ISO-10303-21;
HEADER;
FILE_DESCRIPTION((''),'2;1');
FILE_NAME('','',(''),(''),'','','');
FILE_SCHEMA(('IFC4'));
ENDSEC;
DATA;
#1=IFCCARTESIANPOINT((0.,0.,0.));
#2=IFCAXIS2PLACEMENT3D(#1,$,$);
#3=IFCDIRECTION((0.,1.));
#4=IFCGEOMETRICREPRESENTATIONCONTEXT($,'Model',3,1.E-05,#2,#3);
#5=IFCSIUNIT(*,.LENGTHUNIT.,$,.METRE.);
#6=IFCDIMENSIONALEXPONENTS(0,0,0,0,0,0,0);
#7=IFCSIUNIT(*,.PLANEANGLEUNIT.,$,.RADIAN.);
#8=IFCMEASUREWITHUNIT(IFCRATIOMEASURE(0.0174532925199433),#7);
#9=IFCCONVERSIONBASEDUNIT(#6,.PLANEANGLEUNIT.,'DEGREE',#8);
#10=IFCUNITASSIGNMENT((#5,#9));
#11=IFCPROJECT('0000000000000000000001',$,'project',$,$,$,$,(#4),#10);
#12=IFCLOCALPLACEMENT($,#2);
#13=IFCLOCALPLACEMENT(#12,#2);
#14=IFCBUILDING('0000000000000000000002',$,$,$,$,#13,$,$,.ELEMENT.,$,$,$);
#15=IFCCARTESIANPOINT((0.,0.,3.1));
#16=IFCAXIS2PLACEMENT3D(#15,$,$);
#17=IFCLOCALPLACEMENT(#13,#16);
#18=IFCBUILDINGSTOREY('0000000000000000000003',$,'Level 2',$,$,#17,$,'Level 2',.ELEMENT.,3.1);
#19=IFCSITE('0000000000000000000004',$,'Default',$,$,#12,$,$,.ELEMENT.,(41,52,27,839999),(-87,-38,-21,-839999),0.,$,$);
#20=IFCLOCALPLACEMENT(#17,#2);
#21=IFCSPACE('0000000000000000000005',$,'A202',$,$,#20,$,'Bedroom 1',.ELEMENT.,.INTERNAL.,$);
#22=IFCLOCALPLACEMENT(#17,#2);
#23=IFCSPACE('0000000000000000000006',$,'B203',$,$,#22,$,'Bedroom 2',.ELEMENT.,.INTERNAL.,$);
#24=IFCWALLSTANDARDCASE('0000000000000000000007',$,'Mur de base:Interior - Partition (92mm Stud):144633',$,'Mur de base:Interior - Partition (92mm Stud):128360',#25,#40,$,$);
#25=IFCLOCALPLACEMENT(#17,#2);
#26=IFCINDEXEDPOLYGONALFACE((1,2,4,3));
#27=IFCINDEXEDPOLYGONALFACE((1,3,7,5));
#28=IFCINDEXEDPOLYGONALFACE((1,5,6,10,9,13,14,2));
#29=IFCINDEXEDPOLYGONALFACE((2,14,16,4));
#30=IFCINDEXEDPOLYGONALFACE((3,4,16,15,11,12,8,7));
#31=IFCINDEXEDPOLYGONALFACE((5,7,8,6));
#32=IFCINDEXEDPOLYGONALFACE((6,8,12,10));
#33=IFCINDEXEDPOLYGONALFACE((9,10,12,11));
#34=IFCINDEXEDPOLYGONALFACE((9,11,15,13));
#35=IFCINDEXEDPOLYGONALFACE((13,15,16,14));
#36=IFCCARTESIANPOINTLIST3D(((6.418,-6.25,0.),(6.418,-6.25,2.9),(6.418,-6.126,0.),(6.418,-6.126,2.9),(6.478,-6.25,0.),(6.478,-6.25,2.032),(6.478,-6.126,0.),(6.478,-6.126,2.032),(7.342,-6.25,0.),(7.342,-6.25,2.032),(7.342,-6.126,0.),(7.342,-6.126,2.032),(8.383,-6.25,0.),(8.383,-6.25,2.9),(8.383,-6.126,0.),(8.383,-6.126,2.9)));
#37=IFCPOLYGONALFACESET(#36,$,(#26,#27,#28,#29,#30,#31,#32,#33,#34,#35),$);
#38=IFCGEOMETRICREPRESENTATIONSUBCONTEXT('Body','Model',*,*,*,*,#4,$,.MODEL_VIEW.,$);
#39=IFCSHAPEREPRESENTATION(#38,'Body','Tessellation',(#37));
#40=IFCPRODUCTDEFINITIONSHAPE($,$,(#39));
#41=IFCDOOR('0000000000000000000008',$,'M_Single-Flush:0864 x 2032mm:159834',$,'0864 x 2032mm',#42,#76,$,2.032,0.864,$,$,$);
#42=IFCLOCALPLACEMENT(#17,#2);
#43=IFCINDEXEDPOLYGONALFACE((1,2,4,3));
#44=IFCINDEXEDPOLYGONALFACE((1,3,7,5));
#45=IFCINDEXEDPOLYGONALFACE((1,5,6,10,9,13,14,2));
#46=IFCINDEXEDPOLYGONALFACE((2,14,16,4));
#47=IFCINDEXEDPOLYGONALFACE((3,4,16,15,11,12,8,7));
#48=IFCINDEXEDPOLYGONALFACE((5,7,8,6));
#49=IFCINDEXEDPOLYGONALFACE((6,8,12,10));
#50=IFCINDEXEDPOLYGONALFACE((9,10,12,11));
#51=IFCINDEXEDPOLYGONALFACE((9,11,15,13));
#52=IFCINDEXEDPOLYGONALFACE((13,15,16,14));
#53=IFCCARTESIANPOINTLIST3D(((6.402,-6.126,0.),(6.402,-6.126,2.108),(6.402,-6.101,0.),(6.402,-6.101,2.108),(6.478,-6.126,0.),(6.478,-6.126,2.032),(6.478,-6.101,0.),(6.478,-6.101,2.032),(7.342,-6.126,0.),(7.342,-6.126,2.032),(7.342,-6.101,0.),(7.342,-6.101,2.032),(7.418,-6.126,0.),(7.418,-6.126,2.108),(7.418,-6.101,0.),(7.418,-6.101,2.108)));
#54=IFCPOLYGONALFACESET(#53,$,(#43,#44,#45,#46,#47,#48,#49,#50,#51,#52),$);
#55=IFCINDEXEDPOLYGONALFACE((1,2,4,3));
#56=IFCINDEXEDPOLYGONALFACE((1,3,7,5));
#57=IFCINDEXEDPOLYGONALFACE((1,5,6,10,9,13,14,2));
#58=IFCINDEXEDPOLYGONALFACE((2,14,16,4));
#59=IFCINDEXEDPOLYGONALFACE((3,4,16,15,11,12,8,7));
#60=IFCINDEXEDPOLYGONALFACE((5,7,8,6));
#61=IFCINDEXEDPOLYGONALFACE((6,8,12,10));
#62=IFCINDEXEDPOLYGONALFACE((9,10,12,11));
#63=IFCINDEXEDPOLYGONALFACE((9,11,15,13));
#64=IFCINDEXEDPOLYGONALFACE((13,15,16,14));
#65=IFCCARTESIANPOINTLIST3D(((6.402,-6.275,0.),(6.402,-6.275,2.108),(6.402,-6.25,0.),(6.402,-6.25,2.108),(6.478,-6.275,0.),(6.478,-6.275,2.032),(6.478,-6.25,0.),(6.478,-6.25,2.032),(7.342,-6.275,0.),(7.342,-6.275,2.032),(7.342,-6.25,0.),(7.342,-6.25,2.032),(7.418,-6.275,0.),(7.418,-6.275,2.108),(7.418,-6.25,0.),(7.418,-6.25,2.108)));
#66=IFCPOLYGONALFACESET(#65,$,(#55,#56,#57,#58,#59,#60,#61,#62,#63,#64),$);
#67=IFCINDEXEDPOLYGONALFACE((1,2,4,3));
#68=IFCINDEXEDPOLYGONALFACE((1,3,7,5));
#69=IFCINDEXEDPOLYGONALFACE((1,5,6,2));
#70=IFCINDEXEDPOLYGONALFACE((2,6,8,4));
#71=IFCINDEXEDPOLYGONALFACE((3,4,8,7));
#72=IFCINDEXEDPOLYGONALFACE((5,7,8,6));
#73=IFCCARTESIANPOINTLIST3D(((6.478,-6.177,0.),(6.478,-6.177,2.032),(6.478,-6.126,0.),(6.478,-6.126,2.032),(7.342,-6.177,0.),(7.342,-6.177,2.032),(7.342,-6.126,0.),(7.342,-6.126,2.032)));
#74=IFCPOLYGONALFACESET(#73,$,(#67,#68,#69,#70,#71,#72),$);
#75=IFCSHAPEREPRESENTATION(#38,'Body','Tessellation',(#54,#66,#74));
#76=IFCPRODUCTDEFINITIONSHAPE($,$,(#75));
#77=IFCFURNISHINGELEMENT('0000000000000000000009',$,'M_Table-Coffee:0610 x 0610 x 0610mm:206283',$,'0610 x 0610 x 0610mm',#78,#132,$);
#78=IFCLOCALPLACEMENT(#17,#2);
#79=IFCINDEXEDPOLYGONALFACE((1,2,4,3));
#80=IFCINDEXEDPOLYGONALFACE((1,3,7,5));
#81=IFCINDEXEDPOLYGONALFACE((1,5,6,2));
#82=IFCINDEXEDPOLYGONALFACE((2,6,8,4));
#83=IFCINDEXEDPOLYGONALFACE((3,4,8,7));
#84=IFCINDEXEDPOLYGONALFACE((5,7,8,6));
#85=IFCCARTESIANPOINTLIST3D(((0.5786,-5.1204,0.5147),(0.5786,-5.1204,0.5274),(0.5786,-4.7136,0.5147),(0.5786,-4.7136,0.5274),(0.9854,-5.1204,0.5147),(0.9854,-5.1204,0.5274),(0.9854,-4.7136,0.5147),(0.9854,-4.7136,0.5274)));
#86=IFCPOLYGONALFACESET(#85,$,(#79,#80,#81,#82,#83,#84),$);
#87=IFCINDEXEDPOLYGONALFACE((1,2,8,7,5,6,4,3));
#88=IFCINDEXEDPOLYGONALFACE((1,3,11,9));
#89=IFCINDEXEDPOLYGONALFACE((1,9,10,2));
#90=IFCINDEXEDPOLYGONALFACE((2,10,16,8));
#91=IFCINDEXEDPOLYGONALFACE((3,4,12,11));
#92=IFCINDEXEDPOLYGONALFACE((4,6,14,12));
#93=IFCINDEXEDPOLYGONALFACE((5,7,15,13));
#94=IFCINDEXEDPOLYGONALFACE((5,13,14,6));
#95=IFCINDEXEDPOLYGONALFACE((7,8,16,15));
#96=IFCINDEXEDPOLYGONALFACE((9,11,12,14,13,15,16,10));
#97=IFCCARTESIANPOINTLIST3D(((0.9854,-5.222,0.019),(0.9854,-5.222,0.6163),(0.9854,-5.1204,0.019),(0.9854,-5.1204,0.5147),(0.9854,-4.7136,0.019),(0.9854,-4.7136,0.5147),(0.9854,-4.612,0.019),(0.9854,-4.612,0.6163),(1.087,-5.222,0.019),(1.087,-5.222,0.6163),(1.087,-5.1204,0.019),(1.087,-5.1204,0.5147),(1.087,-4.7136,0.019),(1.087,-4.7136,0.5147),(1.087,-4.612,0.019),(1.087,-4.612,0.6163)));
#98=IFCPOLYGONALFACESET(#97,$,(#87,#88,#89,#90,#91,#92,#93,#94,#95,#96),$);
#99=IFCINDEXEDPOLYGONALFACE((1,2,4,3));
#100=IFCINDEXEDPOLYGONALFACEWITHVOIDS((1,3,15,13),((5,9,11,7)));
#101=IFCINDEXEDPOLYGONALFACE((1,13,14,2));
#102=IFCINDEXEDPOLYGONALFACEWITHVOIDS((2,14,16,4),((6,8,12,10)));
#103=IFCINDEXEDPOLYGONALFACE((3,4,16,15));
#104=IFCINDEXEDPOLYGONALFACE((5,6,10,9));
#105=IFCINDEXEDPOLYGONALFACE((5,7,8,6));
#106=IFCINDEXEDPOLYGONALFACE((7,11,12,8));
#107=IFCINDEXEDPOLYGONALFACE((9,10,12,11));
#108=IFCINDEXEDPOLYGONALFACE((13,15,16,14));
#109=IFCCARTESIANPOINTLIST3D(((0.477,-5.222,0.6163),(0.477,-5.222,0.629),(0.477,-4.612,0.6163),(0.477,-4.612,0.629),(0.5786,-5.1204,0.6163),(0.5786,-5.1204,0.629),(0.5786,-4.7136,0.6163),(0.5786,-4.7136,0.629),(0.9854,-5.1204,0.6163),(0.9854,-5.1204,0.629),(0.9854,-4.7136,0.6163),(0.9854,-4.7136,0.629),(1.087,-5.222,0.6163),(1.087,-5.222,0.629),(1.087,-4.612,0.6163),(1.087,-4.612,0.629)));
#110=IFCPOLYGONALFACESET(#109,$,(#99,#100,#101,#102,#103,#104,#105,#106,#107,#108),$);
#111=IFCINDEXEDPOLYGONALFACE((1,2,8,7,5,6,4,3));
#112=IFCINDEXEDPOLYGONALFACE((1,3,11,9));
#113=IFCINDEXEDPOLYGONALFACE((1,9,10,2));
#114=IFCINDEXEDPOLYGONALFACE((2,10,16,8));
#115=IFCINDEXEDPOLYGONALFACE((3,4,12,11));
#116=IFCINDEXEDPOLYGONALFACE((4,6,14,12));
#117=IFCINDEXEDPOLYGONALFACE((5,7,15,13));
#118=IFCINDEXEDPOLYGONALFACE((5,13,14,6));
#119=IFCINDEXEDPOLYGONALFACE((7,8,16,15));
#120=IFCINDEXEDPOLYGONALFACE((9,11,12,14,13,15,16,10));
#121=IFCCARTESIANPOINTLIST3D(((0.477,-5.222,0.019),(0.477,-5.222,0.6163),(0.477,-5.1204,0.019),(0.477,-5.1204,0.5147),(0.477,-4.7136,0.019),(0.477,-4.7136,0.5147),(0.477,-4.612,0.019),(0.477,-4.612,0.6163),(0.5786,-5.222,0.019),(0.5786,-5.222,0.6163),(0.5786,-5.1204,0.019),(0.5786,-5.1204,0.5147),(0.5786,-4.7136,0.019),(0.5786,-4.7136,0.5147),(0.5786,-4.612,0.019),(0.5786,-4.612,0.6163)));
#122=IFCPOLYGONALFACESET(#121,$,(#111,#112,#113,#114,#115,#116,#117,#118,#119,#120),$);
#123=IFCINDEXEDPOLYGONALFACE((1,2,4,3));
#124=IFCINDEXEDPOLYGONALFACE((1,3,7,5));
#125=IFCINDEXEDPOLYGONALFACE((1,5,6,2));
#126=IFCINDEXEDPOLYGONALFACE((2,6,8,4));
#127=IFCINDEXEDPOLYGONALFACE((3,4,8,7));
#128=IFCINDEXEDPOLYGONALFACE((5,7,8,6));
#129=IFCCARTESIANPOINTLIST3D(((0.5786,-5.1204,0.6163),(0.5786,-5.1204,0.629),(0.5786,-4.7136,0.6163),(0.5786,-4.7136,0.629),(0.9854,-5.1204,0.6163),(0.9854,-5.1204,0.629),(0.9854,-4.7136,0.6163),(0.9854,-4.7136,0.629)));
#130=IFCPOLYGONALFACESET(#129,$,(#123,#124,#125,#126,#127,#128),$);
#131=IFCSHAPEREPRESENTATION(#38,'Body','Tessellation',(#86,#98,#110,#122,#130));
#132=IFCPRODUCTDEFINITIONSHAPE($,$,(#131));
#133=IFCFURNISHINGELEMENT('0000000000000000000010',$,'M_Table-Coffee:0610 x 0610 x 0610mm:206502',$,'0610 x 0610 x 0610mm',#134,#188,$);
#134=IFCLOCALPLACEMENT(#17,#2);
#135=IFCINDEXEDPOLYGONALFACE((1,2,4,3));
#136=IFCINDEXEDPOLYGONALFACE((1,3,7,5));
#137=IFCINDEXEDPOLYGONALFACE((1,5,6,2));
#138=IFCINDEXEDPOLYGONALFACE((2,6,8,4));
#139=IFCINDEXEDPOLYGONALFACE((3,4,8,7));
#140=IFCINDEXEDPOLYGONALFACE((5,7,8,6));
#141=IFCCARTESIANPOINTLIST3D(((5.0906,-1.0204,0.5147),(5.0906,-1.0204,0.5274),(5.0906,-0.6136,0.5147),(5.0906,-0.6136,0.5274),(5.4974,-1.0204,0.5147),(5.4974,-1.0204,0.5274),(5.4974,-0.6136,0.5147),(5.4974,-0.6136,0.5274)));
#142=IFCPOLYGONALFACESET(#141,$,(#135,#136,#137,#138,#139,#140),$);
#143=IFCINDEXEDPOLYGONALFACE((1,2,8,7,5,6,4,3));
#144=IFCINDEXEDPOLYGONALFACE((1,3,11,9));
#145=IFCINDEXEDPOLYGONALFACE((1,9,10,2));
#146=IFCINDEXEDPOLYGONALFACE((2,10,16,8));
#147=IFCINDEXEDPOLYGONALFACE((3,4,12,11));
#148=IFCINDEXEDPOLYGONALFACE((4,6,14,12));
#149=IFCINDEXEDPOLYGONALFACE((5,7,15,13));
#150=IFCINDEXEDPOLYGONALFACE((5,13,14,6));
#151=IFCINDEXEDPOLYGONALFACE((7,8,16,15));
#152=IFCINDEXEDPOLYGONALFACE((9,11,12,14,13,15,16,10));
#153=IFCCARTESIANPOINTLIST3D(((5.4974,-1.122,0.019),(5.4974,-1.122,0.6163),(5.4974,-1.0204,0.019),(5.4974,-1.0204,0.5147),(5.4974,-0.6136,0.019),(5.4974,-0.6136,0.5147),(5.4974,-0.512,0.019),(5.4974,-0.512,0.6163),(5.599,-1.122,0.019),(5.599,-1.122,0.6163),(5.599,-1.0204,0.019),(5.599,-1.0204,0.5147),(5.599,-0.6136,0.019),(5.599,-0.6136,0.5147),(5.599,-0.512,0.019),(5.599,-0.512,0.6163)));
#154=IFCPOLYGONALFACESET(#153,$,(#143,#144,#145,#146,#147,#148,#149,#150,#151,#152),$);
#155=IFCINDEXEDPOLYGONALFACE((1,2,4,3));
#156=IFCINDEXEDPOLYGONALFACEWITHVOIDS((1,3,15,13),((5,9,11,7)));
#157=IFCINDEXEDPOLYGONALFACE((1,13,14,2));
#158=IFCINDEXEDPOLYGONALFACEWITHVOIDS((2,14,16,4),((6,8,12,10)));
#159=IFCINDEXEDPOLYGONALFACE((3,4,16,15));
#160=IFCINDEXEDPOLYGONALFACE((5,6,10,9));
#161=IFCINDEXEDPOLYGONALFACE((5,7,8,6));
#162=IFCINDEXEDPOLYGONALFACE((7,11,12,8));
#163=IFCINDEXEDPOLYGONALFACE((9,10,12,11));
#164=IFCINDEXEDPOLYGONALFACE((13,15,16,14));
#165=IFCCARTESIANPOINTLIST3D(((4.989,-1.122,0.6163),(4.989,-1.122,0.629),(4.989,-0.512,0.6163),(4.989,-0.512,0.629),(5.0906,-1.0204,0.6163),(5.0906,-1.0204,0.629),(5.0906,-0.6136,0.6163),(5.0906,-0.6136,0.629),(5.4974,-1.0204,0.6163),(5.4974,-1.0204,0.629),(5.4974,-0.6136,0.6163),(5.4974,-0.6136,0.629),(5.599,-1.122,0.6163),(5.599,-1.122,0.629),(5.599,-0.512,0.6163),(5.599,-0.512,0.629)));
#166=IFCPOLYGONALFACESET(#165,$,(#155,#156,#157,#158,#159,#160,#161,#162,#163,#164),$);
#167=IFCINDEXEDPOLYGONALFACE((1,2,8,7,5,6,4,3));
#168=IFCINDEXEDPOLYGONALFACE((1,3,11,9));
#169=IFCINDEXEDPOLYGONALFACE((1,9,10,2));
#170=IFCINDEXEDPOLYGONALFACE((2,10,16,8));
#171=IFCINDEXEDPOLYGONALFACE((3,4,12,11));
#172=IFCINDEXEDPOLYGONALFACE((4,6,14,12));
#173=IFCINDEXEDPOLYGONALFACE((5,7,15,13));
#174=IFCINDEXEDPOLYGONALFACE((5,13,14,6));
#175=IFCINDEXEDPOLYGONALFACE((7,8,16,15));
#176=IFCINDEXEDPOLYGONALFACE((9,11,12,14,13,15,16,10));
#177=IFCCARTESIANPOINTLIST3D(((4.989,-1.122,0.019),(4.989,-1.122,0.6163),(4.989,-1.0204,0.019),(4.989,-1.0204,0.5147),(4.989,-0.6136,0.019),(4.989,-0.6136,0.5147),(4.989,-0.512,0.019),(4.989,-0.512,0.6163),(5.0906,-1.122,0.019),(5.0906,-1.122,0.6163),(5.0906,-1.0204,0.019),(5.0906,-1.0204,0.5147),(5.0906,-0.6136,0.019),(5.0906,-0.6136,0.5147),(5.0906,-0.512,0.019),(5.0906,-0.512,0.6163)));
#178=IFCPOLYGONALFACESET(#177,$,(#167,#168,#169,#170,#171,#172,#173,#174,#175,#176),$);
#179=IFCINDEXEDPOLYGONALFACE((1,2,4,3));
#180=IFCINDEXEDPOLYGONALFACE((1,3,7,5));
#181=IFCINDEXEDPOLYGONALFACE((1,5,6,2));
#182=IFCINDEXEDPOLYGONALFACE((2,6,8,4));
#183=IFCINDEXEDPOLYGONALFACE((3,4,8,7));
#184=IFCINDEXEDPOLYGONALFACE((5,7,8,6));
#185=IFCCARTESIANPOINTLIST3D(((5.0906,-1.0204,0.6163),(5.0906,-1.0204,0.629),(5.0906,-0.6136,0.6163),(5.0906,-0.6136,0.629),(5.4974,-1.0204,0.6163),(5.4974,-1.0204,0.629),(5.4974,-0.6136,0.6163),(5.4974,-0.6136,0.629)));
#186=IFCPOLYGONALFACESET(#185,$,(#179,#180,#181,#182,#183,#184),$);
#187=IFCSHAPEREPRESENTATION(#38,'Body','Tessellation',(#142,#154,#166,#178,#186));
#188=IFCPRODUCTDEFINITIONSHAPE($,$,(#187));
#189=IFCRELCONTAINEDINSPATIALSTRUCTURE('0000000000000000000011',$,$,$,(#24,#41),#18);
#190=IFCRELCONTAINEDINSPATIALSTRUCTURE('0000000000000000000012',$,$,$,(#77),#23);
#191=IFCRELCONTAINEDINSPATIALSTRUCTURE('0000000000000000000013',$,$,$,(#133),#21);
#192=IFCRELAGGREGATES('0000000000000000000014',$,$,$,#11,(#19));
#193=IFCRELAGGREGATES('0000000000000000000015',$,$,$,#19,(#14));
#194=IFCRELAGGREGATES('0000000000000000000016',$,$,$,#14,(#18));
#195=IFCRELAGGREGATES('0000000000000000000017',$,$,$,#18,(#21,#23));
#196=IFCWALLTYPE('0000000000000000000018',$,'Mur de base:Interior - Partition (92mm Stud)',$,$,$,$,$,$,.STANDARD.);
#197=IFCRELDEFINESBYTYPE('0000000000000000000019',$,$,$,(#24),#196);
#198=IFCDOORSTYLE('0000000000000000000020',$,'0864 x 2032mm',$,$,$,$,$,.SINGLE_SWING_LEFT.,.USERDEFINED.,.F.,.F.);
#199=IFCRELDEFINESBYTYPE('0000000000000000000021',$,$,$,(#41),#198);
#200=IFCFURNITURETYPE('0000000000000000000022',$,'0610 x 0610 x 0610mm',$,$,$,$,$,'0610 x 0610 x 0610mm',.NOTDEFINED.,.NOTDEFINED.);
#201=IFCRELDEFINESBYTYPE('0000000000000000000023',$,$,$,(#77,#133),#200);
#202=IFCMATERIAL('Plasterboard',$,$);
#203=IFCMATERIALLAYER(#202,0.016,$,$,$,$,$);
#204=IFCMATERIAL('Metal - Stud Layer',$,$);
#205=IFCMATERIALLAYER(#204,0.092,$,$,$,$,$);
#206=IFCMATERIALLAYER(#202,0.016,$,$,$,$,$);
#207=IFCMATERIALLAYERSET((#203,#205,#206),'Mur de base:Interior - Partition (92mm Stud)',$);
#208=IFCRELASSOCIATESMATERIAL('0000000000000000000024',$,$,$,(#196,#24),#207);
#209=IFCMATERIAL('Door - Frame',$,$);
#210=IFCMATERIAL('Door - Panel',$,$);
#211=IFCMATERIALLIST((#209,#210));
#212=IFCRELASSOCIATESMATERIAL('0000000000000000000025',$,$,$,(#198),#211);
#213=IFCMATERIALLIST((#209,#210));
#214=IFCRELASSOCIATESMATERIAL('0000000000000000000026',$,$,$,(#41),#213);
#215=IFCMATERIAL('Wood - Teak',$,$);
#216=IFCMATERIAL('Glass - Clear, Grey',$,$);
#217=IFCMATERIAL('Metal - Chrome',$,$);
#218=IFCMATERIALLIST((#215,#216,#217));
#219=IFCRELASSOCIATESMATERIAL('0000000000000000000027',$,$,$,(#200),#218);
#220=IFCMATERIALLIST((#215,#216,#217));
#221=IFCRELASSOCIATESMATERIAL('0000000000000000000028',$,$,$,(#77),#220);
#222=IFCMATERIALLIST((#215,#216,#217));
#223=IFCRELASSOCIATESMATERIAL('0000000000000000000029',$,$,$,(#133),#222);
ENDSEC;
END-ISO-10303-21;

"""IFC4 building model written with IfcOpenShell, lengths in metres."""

from ifc_helpers import new_model, entity, si_unit, converted_unit, direction, frame, frame_2d, origin, origin_2d_with_axis, place, context, subcontext, project, spatial, polyline, rectangle, outline, extrude, source, transform, mapped, material, material_list, layer, layer_set, layer_usage, type_object, type_shapes, element, fill, save


model = new_model("IFC4")

# Units and contexts
model_context = context("Model", 3, precision=1e-05, world=origin(), true_north=direction((0.0, 1.0)))
body_context = subcontext(model_context, "Body", "Model", "MODEL_VIEW")
ifc_project = project(units=[si_unit("LENGTHUNIT", "METRE"), converted_unit("PLANEANGLEUNIT", "DEGREE", entity("IfcRatioMeasure", 0.0174532925199433), si_unit("PLANEANGLEUNIT", "RADIAN"), dimensions=[0, 0, 0, 0, 0, 0, 0])], contexts=[model_context])

# Site, building, storey
site_placement = place(None, origin())
site = spatial("IfcSite", under=ifc_project, at=site_placement, Name="Default", CompositionType="ELEMENT", RefLatitude=(41, 52, 27, 839999), RefLongitude=(-87, -38, -21, -839999), RefElevation=0.0)
building_placement = place(site_placement, origin())
building = spatial("IfcBuilding", under=site, at=building_placement, CompositionType="ELEMENT")
storey_placement = place(building_placement, frame((0.0, 0.0, 3.1)))
storey = spatial("IfcBuildingStorey", under=building, at=storey_placement, Name="Level 2", LongName="Level 2", CompositionType="ELEMENT", Elevation=3.1)

# Shared definitions
ifc_material_1 = material(Name="Metal - Stud Layer")
ifc_material_2 = material(Name="Plasterboard")
ifc_layer_1 = layer(ifc_material_2, 0.016)
ifc_layer_2 = layer(ifc_material_1, 0.092)
ifc_layer_3 = layer(ifc_material_2, 0.016)
ifc_layer_set_1 = layer_set([ifc_layer_1, ifc_layer_2, ifc_layer_3], Name="Mur de base:Interior - Partition (92mm Stud)")
wall_type_1 = type_object("IfcWallType", Name="Mur de base:Interior - Partition (92mm Stud)", PredefinedType="STANDARD", material=ifc_layer_set_1)

# Wall, opening, door
ifc_material_3 = material(Name="Door - Frame")
ifc_material_4 = material(Name="Door - Panel")
ifc_layer_usage_1 = layer_usage(ifc_layer_set_1, "AXIS2", "NEGATIVE", 0.062)
wall_1_placement = place(storey_placement, frame((6.418, -6.188, 0.0)))
wall_1 = element("IfcWallStandardCase", 1, at=wall_1_placement, inside=storey, type_object=wall_type_1, material=ifc_layer_usage_1, Name="Mur de base:Interior - Partition (92mm Stud):144633", ObjectType="Mur de base:Interior - Partition (92mm Stud):128360", context=body_context, shape_type="SweptSolid", body=[
    extrude(rectangle(XDim=1.965, YDim=0.124, at=frame_2d((0.9825, 0.0), x_axis=(-1.0, 0.0))), origin(), (0.0, 0.0, 1.0), 2.9),
])
opening_1_placement = place(wall_1_placement, frame((0.06, -0.062, 0.0)))
opening_1 = element("IfcOpeningElement", 2, at=opening_1_placement, cuts=wall_1, ObjectType="Opening", context=body_context, shape_type="SweptSolid", body=[
    extrude(rectangle(XDim=0.864, YDim=2.032, at=frame_2d((1.016, 0.432), x_axis=(0.0, -1.0))), frame((0.0, 0.0, 0.0), z_axis=(0.0, 1.0, 0.0), x_axis=(0.0, 0.0, 1.0)), (0.0, 0.0, 1.0), 0.124),
])
ifc_material_list_1 = material_list([ifc_material_3, ifc_material_4])
ifc_material_list_2 = material_list([ifc_material_3, ifc_material_4])
door_style_1 = type_object("IfcDoorStyle", Name="0864 x 2032mm", ConstructionType="USERDEFINED", OperationType="SINGLE_SWING_LEFT", ParameterTakesPrecedence=False, Sizeable=False, material=ifc_material_list_2)
shared_shape_1 = source(origin(), body_context, "Body", "SweptSolid", [
    extrude(outline(polyline([(-0.508, -1.073), (0.508, -1.073), (0.508, 1.035), (0.432, 1.035), (0.432, -0.997), (-0.432, -0.997), (-0.432, 1.035), (-0.508, 1.035), (-0.508, -1.073)])), frame((0.432, 0.149, 1.035), z_axis=(0.0, -1.0, 0.0), x_axis=(-1.0, 0.0, 0.0)), (0.0, 0.0, 1.0), 0.025),
    extrude(outline(polyline([(-1.073, -0.508), (1.035, -0.508), (1.035, -0.432), (-0.997, -0.432), (-0.997, 0.432), (1.035, 0.432), (1.035, 0.508), (-1.073, 0.508), (-1.073, -0.508)])), frame((0.432, 0.0, 1.035), z_axis=(0.0, -1.0, 0.0), x_axis=(0.0, 0.0, -1.0)), (0.0, 0.0, 1.0), 0.025),
    extrude(rectangle(XDim=0.864, YDim=0.051, at=frame_2d((0.0, 0.0), x_axis=(1.0, 0.0))), frame((0.432, 0.0985, 0.0)), (0.0, 0.0, 1.0), 2.032),
])
type_shapes(door_style_1, [shared_shape_1])
door_1_placement = place(opening_1_placement, origin())
door_1 = element("IfcDoor", 3, at=door_1_placement, inside=storey, type_object=door_style_1, material=ifc_material_list_1, Name="M_Single-Flush:0864 x 2032mm:159834", ObjectType="0864 x 2032mm", OverallHeight=2.032, OverallWidth=0.864, context=body_context, shape_type="MappedRepresentation", body=[
    mapped(shared_shape_1, transform((0.0, 0.0, 0.0), scale=1.0)),
])
fill(opening_1, door_1)

# Shared definitions
space_1_placement = place(storey_placement, origin())
space_1 = spatial("IfcSpace", under=storey, at=space_1_placement, Name="A202", LongName="Bedroom 1", CompositionType="ELEMENT", PredefinedType="INTERNAL")

# Shared definitions
space_2_placement = place(storey_placement, origin())
space_2 = spatial("IfcSpace", under=storey, at=space_2_placement, Name="B203", LongName="Bedroom 2", CompositionType="ELEMENT", PredefinedType="INTERNAL")

# Furnishing elements
ifc_material_5 = material(Name="Wood - Teak")
ifc_material_6 = material(Name="Glass - Clear, Grey")
ifc_material_7 = material(Name="Metal - Chrome")
ifc_material_list_3 = material_list([ifc_material_5, ifc_material_6, ifc_material_7])
ifc_material_list_4 = material_list([ifc_material_5, ifc_material_6, ifc_material_7])
furniture_type_1 = type_object("IfcFurnitureType", Name="0610 x 0610 x 0610mm", ElementType="0610 x 0610 x 0610mm", AssemblyPlace="NOTDEFINED", material=ifc_material_list_4)
shared_shape_2 = source(origin(), body_context, "Body", "SweptSolid", [
    extrude(rectangle(XDim=0.4068, YDim=0.4068, at=origin_2d_with_axis()), frame((0.0183, 0.0952, 0.4957), z_axis=(0.0, 0.0, 1.0), x_axis=(-1.0, 0.0, 0.0)), (0.0, 0.0, 1.0), 0.0127),
    extrude(outline(polyline([(-0.2732, -0.305), (0.324, -0.305), (0.324, 0.305), (-0.2732, 0.305), (-0.2732, 0.2034), (0.2225, 0.2034), (0.2225, -0.2034), (-0.2732, -0.2034), (-0.2732, -0.305)])), frame((0.2217, 0.0952, 0.2732), z_axis=(1.0, 0.0, 0.0), x_axis=(0.0, 0.0, 1.0)), (0.0, 0.0, 1.0), 0.1016),
    extrude(outline(polyline([(-0.305, -0.305), (0.305, -0.305), (0.305, 0.305), (-0.305, 0.305), (-0.305, -0.305)]), holes=[polyline([(-0.2034, -0.2034), (-0.2034, 0.2034), (0.2034, 0.2034), (0.2034, -0.2034), (-0.2034, -0.2034)])]), frame((0.0183, 0.0952, 0.5973), z_axis=(0.0, 0.0, 1.0), x_axis=(-1.0, 0.0, 0.0)), (0.0, 0.0, 1.0), 0.0127),
    extrude(outline(polyline([(-0.305, -0.3241), (0.305, -0.3241), (0.305, 0.2733), (0.2034, 0.2733), (0.2034, -0.2224), (-0.2034, -0.2224), (-0.2034, 0.2733), (-0.305, 0.2733), (-0.305, -0.3241)])), frame((-0.2867, 0.0952, 0.2733), z_axis=(1.0, 0.0, 0.0), x_axis=(0.0, -1.0, 0.0)), (0.0, 0.0, 1.0), 0.1016),
    extrude(rectangle(XDim=0.4068, YDim=0.4068, at=origin_2d_with_axis()), frame((0.0183, 0.0952, 0.5973), z_axis=(0.0, 0.0, 1.0), x_axis=(-1.0, 0.0, 0.0)), (0.0, 0.0, 1.0), 0.0127),
])
type_shapes(furniture_type_1, [shared_shape_2])
furnishing_1_placement = place(space_2_placement, frame((0.7637, -5.0122, 0.019)))
element("IfcFurnishingElement", 4, at=furnishing_1_placement, inside=space_2, type_object=furniture_type_1, material=ifc_material_list_3, Name="M_Table-Coffee:0610 x 0610 x 0610mm:206283", ObjectType="0610 x 0610 x 0610mm", context=body_context, shape_type="MappedRepresentation", body=[
    mapped(shared_shape_2, transform((0.0, 0.0, 0.0), scale=1.0)),
])
ifc_material_list_5 = material_list([ifc_material_5, ifc_material_6, ifc_material_7])
furnishing_2_placement = place(space_1_placement, frame((5.2757, -0.9122, 0.019)))
element("IfcFurnishingElement", 5, at=furnishing_2_placement, inside=space_1, type_object=furniture_type_1, material=ifc_material_list_5, Name="M_Table-Coffee:0610 x 0610 x 0610mm:206502", ObjectType="0610 x 0610 x 0610mm", context=body_context, shape_type="MappedRepresentation", body=[
    mapped(shared_shape_2, transform((0.0, 0.0, 0.0), scale=1.0)),
])

save(model, "model.ifc")
